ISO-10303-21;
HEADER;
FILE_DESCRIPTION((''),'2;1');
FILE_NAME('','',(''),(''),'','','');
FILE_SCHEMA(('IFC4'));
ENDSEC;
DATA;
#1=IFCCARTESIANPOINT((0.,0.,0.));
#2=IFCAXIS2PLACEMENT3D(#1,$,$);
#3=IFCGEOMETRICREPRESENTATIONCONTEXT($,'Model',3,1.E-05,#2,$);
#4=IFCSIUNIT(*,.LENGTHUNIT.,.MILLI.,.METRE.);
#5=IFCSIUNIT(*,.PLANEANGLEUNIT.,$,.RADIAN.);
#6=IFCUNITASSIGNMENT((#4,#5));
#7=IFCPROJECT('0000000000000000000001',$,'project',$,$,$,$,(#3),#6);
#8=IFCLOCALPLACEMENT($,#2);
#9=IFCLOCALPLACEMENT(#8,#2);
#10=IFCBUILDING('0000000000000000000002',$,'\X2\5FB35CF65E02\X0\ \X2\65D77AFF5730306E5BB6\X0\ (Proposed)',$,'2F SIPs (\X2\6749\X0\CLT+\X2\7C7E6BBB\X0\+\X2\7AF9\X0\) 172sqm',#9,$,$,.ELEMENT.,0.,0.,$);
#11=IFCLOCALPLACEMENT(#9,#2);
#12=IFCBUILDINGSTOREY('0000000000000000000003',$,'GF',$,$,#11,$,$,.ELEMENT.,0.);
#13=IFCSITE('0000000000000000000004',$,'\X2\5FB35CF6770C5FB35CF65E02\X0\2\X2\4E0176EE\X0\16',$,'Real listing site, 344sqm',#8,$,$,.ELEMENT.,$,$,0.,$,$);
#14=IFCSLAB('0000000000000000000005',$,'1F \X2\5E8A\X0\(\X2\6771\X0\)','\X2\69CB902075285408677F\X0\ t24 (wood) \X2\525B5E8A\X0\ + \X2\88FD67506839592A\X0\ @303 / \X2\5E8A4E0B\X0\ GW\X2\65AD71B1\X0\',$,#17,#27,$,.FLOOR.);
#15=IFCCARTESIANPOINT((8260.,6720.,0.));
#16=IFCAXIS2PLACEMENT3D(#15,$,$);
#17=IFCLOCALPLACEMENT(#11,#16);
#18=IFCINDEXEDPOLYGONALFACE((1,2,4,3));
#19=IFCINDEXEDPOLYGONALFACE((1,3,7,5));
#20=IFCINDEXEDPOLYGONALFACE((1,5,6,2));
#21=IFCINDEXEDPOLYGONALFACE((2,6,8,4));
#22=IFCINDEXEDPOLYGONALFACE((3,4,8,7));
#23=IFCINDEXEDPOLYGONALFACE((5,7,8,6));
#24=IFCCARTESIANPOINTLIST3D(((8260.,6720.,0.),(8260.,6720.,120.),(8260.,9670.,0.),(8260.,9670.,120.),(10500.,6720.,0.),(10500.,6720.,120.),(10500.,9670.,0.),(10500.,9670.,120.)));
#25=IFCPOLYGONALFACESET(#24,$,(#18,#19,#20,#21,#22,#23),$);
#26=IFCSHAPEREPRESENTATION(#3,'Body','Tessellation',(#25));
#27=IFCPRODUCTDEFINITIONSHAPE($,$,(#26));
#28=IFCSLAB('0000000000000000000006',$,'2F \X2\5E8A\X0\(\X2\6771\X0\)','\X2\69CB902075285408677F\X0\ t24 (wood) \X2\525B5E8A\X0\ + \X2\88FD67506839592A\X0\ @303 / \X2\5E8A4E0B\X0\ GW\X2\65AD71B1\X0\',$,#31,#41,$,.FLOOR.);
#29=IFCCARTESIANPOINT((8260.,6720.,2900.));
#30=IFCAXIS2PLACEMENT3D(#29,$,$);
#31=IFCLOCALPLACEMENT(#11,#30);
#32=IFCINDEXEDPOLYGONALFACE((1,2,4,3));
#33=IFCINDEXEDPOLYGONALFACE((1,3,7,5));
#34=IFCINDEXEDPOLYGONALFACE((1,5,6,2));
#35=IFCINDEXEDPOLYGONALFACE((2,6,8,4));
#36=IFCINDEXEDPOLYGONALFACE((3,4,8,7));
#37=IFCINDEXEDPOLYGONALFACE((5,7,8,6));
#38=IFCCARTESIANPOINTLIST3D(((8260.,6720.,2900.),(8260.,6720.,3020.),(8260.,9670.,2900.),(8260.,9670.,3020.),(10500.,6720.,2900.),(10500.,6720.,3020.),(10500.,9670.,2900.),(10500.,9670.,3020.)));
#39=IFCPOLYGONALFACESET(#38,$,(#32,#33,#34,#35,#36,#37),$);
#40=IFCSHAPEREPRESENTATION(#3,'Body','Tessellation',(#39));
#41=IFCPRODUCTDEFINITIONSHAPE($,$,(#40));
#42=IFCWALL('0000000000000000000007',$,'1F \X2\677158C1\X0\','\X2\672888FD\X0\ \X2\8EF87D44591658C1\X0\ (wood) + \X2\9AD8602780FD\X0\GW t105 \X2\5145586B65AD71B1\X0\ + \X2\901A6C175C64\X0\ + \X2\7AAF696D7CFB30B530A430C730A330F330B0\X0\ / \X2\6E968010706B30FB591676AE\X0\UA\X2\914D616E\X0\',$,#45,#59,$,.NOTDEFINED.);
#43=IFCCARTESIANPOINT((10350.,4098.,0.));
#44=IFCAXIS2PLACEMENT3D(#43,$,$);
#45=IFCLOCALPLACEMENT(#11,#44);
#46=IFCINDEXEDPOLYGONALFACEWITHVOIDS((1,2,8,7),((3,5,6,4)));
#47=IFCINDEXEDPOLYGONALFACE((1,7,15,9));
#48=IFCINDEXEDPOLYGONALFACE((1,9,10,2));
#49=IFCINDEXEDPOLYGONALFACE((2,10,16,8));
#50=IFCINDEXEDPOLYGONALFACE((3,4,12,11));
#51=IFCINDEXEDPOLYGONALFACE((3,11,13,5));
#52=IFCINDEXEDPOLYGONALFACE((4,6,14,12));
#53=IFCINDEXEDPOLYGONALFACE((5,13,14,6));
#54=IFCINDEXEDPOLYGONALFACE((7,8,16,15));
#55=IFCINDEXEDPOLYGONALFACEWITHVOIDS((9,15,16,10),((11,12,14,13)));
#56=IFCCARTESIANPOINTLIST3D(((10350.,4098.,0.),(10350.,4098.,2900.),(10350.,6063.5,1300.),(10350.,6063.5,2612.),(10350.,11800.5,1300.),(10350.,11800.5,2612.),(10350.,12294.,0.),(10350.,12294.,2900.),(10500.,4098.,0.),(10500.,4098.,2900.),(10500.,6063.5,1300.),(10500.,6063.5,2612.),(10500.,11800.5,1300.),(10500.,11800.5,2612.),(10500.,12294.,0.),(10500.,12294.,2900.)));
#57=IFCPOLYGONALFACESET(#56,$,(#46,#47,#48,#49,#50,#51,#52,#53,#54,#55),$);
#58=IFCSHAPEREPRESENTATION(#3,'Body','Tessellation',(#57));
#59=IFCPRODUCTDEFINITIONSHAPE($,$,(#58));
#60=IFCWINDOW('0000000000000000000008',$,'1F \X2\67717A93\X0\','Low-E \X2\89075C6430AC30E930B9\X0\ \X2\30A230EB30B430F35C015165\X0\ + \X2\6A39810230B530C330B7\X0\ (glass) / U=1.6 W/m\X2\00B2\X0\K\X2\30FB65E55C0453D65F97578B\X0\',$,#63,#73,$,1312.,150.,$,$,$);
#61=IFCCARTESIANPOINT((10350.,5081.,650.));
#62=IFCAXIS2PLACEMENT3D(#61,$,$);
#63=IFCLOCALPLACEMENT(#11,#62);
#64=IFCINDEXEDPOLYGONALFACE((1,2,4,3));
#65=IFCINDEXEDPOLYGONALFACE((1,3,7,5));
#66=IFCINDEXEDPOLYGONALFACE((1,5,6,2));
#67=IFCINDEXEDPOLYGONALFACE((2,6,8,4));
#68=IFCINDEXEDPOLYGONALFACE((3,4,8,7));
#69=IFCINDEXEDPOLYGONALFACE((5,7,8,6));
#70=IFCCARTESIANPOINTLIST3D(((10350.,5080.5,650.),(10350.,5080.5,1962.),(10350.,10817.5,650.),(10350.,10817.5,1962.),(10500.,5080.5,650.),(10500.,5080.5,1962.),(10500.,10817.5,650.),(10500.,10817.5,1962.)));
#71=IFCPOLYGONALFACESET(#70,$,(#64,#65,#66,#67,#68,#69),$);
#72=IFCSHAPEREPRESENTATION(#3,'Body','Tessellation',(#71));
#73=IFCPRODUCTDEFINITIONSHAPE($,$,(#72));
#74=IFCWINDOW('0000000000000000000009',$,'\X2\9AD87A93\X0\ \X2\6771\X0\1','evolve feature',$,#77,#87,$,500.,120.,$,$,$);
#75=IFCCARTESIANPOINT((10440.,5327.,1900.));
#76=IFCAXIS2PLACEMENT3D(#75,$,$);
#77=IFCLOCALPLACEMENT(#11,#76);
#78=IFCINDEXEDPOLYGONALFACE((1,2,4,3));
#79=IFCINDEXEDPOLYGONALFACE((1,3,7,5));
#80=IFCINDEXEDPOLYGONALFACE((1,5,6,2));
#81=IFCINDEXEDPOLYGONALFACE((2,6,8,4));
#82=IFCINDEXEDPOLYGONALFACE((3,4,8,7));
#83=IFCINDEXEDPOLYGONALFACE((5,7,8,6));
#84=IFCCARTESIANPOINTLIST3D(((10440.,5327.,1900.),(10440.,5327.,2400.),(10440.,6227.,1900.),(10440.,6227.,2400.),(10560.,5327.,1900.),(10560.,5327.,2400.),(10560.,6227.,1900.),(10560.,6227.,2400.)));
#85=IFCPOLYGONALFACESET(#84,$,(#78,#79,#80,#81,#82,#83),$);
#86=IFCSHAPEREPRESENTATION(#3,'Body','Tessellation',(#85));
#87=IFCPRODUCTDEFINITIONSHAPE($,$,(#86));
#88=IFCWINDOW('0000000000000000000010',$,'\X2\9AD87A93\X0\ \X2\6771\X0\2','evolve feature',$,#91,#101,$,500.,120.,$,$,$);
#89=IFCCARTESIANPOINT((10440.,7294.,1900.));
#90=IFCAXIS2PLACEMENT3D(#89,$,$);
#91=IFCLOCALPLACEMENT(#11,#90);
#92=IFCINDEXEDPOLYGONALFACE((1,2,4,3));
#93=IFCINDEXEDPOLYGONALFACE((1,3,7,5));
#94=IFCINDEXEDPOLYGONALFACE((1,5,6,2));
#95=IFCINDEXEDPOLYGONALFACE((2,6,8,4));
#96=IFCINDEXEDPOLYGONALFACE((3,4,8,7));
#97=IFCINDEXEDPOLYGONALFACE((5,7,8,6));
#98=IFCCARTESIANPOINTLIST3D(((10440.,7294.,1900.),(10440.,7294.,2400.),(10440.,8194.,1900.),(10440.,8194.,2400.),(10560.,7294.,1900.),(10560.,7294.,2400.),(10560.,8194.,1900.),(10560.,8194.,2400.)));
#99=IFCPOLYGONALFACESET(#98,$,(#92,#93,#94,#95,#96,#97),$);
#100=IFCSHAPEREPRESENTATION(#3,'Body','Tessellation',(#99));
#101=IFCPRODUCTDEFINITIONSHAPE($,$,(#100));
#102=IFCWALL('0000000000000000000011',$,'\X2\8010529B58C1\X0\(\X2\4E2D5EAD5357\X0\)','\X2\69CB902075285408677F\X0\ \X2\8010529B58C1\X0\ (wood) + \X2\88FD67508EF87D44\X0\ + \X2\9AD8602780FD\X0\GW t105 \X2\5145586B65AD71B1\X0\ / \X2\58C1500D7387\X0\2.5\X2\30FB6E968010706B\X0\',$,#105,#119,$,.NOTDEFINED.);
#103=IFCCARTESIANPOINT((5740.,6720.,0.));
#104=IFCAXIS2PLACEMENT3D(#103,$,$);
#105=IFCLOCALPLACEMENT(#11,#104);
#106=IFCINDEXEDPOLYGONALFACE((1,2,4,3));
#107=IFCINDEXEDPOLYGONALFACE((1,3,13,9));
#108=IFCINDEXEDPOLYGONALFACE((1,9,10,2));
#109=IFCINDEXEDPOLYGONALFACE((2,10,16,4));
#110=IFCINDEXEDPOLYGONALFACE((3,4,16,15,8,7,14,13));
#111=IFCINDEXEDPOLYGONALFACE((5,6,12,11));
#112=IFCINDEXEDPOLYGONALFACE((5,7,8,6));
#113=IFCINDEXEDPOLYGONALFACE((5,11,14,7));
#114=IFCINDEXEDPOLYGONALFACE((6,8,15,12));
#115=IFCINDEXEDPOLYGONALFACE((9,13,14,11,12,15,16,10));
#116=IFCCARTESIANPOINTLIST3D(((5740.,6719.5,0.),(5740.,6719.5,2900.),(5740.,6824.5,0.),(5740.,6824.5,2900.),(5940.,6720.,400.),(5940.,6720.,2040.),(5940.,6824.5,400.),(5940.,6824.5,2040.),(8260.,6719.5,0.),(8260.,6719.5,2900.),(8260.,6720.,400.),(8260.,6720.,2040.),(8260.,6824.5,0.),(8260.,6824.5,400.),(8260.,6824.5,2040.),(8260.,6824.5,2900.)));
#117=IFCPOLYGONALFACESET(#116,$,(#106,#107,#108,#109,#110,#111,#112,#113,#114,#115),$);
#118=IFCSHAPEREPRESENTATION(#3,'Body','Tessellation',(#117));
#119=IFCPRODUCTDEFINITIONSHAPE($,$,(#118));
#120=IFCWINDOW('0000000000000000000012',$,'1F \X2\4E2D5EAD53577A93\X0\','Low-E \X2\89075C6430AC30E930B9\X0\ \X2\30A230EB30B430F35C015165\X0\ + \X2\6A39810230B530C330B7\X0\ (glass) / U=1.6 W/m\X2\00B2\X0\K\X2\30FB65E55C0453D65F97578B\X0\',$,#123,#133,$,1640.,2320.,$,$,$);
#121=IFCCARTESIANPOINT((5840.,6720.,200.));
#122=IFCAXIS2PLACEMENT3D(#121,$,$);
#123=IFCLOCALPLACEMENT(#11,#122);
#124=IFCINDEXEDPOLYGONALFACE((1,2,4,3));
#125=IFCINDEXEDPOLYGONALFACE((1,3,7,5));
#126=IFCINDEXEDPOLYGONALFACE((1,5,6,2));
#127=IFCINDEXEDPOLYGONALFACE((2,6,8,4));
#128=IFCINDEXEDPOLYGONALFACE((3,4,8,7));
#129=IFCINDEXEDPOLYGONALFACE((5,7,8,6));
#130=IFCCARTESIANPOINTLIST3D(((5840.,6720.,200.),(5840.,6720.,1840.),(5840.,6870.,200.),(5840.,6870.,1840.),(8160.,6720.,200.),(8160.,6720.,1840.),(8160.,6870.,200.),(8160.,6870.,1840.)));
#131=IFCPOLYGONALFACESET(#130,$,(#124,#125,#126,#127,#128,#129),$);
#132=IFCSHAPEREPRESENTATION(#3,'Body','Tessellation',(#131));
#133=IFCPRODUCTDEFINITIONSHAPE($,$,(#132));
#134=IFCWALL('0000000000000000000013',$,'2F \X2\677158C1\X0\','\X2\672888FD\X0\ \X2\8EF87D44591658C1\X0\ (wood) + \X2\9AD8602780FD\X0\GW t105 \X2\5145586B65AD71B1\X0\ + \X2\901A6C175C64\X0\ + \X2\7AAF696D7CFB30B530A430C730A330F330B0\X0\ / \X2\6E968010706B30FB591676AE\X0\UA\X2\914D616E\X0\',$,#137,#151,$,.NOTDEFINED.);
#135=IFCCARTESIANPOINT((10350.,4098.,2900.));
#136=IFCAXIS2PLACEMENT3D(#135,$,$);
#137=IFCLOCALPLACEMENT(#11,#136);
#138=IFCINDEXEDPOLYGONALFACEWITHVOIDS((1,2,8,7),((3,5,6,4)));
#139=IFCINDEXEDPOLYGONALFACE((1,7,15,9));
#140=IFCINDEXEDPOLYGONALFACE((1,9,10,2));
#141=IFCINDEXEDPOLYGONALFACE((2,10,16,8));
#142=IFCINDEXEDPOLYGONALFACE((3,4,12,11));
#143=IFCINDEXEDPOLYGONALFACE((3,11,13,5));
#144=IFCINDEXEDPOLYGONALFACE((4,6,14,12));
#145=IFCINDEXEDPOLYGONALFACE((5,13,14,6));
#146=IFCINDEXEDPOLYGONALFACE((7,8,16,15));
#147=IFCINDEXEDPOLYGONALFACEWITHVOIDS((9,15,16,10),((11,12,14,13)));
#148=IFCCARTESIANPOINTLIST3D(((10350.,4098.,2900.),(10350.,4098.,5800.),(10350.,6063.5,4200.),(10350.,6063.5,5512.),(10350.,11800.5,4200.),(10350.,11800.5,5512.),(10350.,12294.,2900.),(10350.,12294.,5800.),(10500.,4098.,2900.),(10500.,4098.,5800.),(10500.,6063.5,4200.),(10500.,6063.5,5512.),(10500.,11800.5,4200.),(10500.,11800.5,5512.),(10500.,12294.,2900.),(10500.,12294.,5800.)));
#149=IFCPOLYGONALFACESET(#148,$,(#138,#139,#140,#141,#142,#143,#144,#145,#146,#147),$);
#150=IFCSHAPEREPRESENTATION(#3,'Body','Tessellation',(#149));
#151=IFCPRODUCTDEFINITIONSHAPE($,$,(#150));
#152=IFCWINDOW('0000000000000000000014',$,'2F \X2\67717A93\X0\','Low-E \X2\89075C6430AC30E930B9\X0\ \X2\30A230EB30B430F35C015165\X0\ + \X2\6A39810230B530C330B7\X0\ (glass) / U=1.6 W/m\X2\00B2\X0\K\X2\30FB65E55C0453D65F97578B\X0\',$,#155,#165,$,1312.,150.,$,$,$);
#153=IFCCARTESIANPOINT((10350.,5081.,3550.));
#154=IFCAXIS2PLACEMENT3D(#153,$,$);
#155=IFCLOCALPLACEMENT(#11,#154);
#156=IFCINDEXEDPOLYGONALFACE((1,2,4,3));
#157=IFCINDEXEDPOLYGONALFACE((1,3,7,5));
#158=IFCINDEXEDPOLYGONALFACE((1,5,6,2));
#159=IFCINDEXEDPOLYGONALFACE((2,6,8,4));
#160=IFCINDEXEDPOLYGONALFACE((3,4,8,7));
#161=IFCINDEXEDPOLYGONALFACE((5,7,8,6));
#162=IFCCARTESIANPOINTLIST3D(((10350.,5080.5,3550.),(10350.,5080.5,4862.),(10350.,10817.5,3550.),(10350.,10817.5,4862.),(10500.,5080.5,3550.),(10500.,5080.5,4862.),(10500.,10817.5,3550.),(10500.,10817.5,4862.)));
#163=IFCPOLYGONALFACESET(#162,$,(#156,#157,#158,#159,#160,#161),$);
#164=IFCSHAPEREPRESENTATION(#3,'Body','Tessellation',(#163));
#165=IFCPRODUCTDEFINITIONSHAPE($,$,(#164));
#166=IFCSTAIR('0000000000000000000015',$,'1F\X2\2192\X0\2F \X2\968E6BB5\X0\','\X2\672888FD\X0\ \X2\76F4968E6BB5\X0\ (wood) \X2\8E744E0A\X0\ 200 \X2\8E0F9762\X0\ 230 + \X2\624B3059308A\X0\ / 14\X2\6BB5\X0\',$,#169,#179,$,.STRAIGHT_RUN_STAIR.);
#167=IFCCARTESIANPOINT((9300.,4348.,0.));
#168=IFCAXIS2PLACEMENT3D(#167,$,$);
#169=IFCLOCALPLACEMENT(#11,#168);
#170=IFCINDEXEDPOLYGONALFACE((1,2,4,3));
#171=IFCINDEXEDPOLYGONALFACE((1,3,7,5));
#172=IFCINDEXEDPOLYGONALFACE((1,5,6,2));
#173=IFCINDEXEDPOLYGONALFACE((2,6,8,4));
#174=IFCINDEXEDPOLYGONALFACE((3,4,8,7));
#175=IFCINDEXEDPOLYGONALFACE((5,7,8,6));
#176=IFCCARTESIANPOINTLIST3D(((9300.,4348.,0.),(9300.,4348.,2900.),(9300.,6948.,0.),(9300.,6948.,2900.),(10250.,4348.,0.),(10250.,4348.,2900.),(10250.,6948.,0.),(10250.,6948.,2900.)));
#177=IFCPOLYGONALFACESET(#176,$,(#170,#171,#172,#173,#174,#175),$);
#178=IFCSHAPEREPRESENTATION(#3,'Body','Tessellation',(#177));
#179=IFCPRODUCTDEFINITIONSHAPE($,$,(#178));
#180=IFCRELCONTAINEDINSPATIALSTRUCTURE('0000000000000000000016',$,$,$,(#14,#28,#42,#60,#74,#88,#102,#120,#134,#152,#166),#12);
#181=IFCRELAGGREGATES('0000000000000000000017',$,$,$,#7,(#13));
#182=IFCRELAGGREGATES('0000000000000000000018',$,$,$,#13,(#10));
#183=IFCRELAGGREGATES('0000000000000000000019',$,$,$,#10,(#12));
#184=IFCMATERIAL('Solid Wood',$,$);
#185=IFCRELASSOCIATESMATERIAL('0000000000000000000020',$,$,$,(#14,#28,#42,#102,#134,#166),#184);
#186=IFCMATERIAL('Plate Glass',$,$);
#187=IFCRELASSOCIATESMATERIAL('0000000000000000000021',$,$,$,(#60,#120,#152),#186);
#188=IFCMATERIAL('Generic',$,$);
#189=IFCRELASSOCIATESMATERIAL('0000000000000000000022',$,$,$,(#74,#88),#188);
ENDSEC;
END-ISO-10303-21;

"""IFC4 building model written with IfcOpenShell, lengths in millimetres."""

from ifc_helpers import new_model, si_unit, frame, frame_2d, origin, place, context, project, spatial, rectangle, extrude, material, element, fill, save


model = new_model("IFC4")

# Units and contexts
model_context = context("Model", 3, precision=1e-05, world=origin())
ifc_project = project(units=[si_unit("LENGTHUNIT", "METRE", prefix="MILLI"), si_unit("PLANEANGLEUNIT", "RADIAN")], contexts=[model_context])

# Site, building, storey
site_placement = place(None, origin())
site = spatial("IfcSite", under=ifc_project, at=site_placement, Name="徳島県徳島市2丁目16", ObjectType="Real listing site, 344sqm", CompositionType="ELEMENT", RefElevation=0.0)
building_placement = place(site_placement, origin())
building = spatial("IfcBuilding", under=site, at=building_placement, Name="徳島市 旗竿地の家 (Proposed)", ObjectType="2F SIPs (杉CLT+籾殻+竹) 172sqm", CompositionType="ELEMENT", ElevationOfRefHeight=0.0, ElevationOfTerrain=0.0)
storey_placement = place(building_placement, origin())
storey = spatial("IfcBuildingStorey", under=building, at=storey_placement, Name="GF", CompositionType="ELEMENT", Elevation=0.0)

# Slabs
ifc_material_1 = material(Name="Solid Wood")
slab_1_placement = place(storey_placement, frame((8260.0, 6720.0, 0.0)))
element("IfcSlab", 1, at=slab_1_placement, inside=storey, material=ifc_material_1, Name="1F 床(東)", Description="構造用合板 t24 (wood) 剛床 + 製材根太 @303 / 床下 GW断熱", PredefinedType="FLOOR", context=model_context, shape_type="SweptSolid", body=[
    extrude(rectangle(XDim=2240.0, YDim=2950.0, at=frame_2d((1120.0, 1475.0))), frame((8260.0, 6720.0, 0.0)), (0.0, 0.0, 1.0), 120.0),
])
slab_2_placement = place(storey_placement, frame((8260.0, 6720.0, 2900.0)))
element("IfcSlab", 2, at=slab_2_placement, inside=storey, material=ifc_material_1, Name="2F 床(東)", Description="構造用合板 t24 (wood) 剛床 + 製材根太 @303 / 床下 GW断熱", PredefinedType="FLOOR", context=model_context, shape_type="SweptSolid", body=[
    extrude(rectangle(XDim=2240.0, YDim=2950.0, at=frame_2d((1120.0, 1475.0))), frame((8260.0, 6720.0, 2900.0)), (0.0, 0.0, 1.0), 120.0),
])

# Wall, openings, windows
wall_1_placement = place(storey_placement, frame((10350.0, 4098.0, 0.0)))
wall_1 = element("IfcWall", 3, at=wall_1_placement, inside=storey, material=ifc_material_1, Name="1F 東壁", Description="木製 軸組外壁 (wood) + 高性能GW t105 充填断熱 + 通気層 + 窯業系サイディング / 準耐火・外皮UA配慮", PredefinedType="NOTDEFINED", context=model_context, shape_type="SweptSolid", body=[
    extrude(rectangle(XDim=150.0, YDim=8196.0, at=frame_2d((75.0, 4098.0))), frame((10350.0, 4098.0, 0.0)), (0.0, 0.0, 1.0), 2900.0),
])
opening_1_placement = place(storey_placement, frame((10350.0, 5081.0, 650.0)))
opening_1 = element("IfcOpeningElement", 4, at=opening_1_placement, cuts=wall_1, PredefinedType="NOTDEFINED", context=model_context, shape_type="SweptSolid", body=[
    extrude(rectangle(XDim=150.0, YDim=5737.0, at=frame_2d((75.0, 2868.0))), frame((10350.0, 5081.0, 650.0)), (0.0, 0.0, 1.0), 1312.0),
])
opening_2_placement = place(storey_placement, frame((10440.0, 5327.0, 1900.0)))
opening_2 = element("IfcOpeningElement", 5, at=opening_2_placement, cuts=wall_1, PredefinedType="NOTDEFINED", context=model_context, shape_type="SweptSolid", body=[
    extrude(rectangle(XDim=120.0, YDim=900.0, at=frame_2d((60.0, 450.0))), frame((10440.0, 5327.0, 1900.0)), (0.0, 0.0, 1.0), 500.0),
])
opening_3_placement = place(storey_placement, frame((10440.0, 7294.0, 1900.0)))
opening_3 = element("IfcOpeningElement", 6, at=opening_3_placement, cuts=wall_1, PredefinedType="NOTDEFINED", context=model_context, shape_type="SweptSolid", body=[
    extrude(rectangle(XDim=120.0, YDim=900.0, at=frame_2d((60.0, 450.0))), frame((10440.0, 7294.0, 1900.0)), (0.0, 0.0, 1.0), 500.0),
])
ifc_material_2 = material(Name="Plate Glass")
window_1_placement = place(storey_placement, frame((10350.0, 5081.0, 650.0)))
window_1 = element("IfcWindow", 7, at=window_1_placement, inside=storey, material=ifc_material_2, Name="1F 東窓", Description="Low-E 複層ガラス アルゴン封入 + 樹脂サッシ (glass) / U=1.6 W/m²K・日射取得型", OverallHeight=1312.0, OverallWidth=150.0, context=model_context, shape_type="SweptSolid", body=[
    extrude(rectangle(XDim=150.0, YDim=5737.0, at=frame_2d((75.0, 2868.0))), frame((10350.0, 5081.0, 650.0)), (0.0, 0.0, 1.0), 1312.0),
])
fill(opening_1, window_1)
ifc_material_3 = material(Name="Generic")
window_2_placement = place(storey_placement, frame((10440.0, 5327.0, 1900.0)))
window_2 = element("IfcWindow", 8, at=window_2_placement, inside=storey, material=ifc_material_3, Name="高窓 東1", Description="evolve feature", OverallHeight=500.0, OverallWidth=120.0, context=model_context, shape_type="SweptSolid", body=[
    extrude(rectangle(XDim=120.0, YDim=900.0, at=frame_2d((60.0, 450.0))), frame((10440.0, 5327.0, 1900.0)), (0.0, 0.0, 1.0), 500.0),
])
fill(opening_2, window_2)
window_3_placement = place(storey_placement, frame((10440.0, 7294.0, 1900.0)))
window_3 = element("IfcWindow", 9, at=window_3_placement, inside=storey, material=ifc_material_3, Name="高窓 東2", Description="evolve feature", OverallHeight=500.0, OverallWidth=120.0, context=model_context, shape_type="SweptSolid", body=[
    extrude(rectangle(XDim=120.0, YDim=900.0, at=frame_2d((60.0, 450.0))), frame((10440.0, 7294.0, 1900.0)), (0.0, 0.0, 1.0), 500.0),
])
fill(opening_3, window_3)

# Wall, opening, window
wall_2_placement = place(storey_placement, frame((5740.0, 6720.0, 0.0)))
wall_2 = element("IfcWall", 10, at=wall_2_placement, inside=storey, material=ifc_material_1, Name="耐力壁(中庭南)", Description="構造用合板 耐力壁 (wood) + 製材軸組 + 高性能GW t105 充填断熱 / 壁倍率2.5・準耐火", PredefinedType="NOTDEFINED", context=model_context, shape_type="SweptSolid", body=[
    extrude(rectangle(XDim=2520.0, YDim=105.0, at=frame_2d((1260.0, 52.0))), frame((5740.0, 6720.0, 0.0)), (0.0, 0.0, 1.0), 2900.0),
])
opening_4_placement = place(storey_placement, frame((5840.0, 6720.0, 200.0)))
opening_4 = element("IfcOpeningElement", 11, at=opening_4_placement, cuts=wall_2, PredefinedType="NOTDEFINED", context=model_context, shape_type="SweptSolid", body=[
    extrude(rectangle(XDim=2320.0, YDim=150.0, at=frame_2d((1160.0, 75.0))), frame((5840.0, 6720.0, 200.0)), (0.0, 0.0, 1.0), 1640.0),
])
window_4_placement = place(storey_placement, frame((5840.0, 6720.0, 200.0)))
window_4 = element("IfcWindow", 12, at=window_4_placement, inside=storey, material=ifc_material_2, Name="1F 中庭南窓", Description="Low-E 複層ガラス アルゴン封入 + 樹脂サッシ (glass) / U=1.6 W/m²K・日射取得型", OverallHeight=1640.0, OverallWidth=2320.0, context=model_context, shape_type="SweptSolid", body=[
    extrude(rectangle(XDim=2320.0, YDim=150.0, at=frame_2d((1160.0, 75.0))), frame((5840.0, 6720.0, 200.0)), (0.0, 0.0, 1.0), 1640.0),
])
fill(opening_4, window_4)

# Wall, opening, window
wall_3_placement = place(storey_placement, frame((10350.0, 4098.0, 2900.0)))
wall_3 = element("IfcWall", 13, at=wall_3_placement, inside=storey, material=ifc_material_1, Name="2F 東壁", Description="木製 軸組外壁 (wood) + 高性能GW t105 充填断熱 + 通気層 + 窯業系サイディング / 準耐火・外皮UA配慮", PredefinedType="NOTDEFINED", context=model_context, shape_type="SweptSolid", body=[
    extrude(rectangle(XDim=150.0, YDim=8196.0, at=frame_2d((75.0, 4098.0))), frame((10350.0, 4098.0, 2900.0)), (0.0, 0.0, 1.0), 2900.0),
])
opening_5_placement = place(storey_placement, frame((10350.0, 5081.0, 3550.0)))
opening_5 = element("IfcOpeningElement", 14, at=opening_5_placement, cuts=wall_3, PredefinedType="NOTDEFINED", context=model_context, shape_type="SweptSolid", body=[
    extrude(rectangle(XDim=150.0, YDim=5737.0, at=frame_2d((75.0, 2868.0))), frame((10350.0, 5081.0, 3550.0)), (0.0, 0.0, 1.0), 1312.0),
])
window_5_placement = place(storey_placement, frame((10350.0, 5081.0, 3550.0)))
window_5 = element("IfcWindow", 15, at=window_5_placement, inside=storey, material=ifc_material_2, Name="2F 東窓", Description="Low-E 複層ガラス アルゴン封入 + 樹脂サッシ (glass) / U=1.6 W/m²K・日射取得型", OverallHeight=1312.0, OverallWidth=150.0, context=model_context, shape_type="SweptSolid", body=[
    extrude(rectangle(XDim=150.0, YDim=5737.0, at=frame_2d((75.0, 2868.0))), frame((10350.0, 5081.0, 3550.0)), (0.0, 0.0, 1.0), 1312.0),
])
fill(opening_5, window_5)

# Stair
stair_placement = place(storey_placement, frame((9300.0, 4348.0, 0.0)))
element("IfcStair", 16, at=stair_placement, inside=storey, material=ifc_material_1, Name="1F→2F 階段", Description="木製 直階段 (wood) 蹴上 200 踏面 230 + 手すり / 14段", PredefinedType="STRAIGHT_RUN_STAIR", context=model_context, shape_type="SweptSolid", body=[
    extrude(rectangle(XDim=950.0, YDim=2600.0, at=frame_2d((475.0, 1300.0))), frame((9300.0, 4348.0, 0.0)), (0.0, 0.0, 1.0), 2900.0),
])

save(model, "model.ifc")
